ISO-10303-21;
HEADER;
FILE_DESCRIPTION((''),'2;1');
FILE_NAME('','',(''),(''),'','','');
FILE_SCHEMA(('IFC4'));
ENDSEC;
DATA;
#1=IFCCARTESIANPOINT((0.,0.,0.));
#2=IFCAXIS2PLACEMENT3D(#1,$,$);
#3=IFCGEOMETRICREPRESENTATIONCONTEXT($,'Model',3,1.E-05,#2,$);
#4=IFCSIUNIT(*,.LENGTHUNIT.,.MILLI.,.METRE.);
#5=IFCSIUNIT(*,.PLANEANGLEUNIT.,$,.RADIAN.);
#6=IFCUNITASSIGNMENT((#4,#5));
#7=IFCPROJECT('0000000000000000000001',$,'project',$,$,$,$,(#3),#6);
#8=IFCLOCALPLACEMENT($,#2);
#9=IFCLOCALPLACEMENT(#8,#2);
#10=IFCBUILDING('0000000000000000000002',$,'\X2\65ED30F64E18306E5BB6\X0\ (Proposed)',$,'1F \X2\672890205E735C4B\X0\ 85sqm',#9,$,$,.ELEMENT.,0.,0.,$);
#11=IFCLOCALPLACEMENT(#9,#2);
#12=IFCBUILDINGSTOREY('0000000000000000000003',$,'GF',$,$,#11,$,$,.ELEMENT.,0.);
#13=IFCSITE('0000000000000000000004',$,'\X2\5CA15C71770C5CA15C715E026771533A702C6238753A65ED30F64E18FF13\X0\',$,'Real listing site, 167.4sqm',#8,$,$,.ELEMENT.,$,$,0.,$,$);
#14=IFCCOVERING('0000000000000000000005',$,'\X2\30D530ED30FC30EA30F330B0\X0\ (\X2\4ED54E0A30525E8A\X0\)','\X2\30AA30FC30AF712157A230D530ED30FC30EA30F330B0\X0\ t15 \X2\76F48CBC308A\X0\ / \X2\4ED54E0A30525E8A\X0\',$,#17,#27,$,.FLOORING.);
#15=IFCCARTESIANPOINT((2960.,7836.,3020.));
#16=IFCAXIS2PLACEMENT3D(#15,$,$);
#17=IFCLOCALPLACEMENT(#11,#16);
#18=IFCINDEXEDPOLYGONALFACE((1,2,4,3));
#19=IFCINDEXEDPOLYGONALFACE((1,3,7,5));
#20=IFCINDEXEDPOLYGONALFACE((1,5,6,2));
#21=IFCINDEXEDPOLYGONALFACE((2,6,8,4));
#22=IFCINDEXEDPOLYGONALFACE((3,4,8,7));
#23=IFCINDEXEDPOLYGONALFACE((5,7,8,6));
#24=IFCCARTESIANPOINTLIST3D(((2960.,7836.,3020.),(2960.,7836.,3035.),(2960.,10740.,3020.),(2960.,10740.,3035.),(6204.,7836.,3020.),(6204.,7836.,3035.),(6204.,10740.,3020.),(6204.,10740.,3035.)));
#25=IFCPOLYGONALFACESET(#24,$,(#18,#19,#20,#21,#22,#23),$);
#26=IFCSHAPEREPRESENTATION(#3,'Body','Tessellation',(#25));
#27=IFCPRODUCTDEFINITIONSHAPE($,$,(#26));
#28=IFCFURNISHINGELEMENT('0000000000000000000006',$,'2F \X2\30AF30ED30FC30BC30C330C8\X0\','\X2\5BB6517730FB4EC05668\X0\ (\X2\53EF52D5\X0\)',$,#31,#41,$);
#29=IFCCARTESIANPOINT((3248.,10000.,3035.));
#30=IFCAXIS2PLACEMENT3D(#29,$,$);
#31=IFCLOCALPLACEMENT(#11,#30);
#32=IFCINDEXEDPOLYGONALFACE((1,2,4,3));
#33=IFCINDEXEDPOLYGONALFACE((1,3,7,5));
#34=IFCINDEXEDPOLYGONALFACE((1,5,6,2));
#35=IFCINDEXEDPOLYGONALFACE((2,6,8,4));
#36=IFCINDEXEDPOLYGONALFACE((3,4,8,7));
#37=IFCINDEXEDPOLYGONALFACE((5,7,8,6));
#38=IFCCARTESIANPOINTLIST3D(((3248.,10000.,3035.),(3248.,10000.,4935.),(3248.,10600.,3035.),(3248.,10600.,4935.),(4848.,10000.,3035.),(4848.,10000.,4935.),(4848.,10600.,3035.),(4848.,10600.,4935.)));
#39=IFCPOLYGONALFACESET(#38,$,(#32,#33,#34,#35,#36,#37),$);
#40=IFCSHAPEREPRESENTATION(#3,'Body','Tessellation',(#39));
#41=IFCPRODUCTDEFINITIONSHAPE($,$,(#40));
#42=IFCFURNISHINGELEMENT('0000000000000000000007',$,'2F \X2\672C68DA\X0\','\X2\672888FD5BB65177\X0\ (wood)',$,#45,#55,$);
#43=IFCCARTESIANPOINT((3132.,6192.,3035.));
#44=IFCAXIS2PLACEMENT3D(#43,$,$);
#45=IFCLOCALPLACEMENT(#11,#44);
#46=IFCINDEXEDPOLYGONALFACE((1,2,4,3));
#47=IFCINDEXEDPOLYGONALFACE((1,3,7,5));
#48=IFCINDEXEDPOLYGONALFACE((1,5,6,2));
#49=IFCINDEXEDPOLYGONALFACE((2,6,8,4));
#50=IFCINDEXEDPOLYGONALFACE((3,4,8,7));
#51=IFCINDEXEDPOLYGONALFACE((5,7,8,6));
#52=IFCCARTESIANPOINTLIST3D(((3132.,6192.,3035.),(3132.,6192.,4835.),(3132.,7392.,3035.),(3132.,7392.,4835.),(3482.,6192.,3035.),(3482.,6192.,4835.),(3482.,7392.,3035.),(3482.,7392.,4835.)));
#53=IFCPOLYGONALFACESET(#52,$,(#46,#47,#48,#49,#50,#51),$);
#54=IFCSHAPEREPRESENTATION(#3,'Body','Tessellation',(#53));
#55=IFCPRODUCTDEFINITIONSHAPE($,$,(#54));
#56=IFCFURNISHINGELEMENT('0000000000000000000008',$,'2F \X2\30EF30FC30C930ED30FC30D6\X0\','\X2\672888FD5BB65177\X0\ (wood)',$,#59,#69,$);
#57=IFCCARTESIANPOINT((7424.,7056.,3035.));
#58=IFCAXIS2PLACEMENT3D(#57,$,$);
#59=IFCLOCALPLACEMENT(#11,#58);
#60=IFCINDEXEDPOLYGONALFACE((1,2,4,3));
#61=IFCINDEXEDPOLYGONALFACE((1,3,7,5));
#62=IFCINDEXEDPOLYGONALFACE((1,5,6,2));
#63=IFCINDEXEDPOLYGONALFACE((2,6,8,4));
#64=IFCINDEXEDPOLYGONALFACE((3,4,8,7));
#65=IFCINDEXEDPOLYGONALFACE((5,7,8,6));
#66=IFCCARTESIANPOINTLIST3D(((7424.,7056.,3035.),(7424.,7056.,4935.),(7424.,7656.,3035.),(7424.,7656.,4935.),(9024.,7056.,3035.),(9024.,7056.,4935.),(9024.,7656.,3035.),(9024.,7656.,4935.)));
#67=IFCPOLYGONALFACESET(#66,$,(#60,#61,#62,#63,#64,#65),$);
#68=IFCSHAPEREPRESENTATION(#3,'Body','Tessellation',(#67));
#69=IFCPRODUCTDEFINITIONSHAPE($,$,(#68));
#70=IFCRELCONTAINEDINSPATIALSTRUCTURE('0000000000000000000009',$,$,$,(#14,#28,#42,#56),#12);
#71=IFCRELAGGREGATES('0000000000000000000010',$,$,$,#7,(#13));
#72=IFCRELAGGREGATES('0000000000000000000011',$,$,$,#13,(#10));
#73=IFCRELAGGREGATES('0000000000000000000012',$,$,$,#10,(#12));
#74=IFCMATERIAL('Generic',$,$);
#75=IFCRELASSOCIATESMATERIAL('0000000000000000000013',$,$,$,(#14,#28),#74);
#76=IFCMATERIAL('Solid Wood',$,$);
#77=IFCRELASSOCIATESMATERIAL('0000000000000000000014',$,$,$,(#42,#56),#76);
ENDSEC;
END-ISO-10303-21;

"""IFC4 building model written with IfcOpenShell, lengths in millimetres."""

from ifc_helpers import new_model, si_unit, frame, frame_2d, origin, place, context, project, spatial, rectangle, extrude, material, element, save


model = new_model("IFC4")

# Units and contexts
model_context = context("Model", 3, precision=1e-05, world=origin())
ifc_project = project(units=[si_unit("LENGTHUNIT", "METRE", prefix="MILLI"), si_unit("PLANEANGLEUNIT", "RADIAN")], contexts=[model_context])

# Site, building, storey
site_placement = place(None, origin())
site = spatial("IfcSite", under=ifc_project, at=site_placement, Name="岡山県岡山市東区瀬戸町旭ヶ丘３", ObjectType="Real listing site, 167.4sqm", CompositionType="ELEMENT", RefElevation=0.0)
building_placement = place(site_placement, origin())
building = spatial("IfcBuilding", under=site, at=building_placement, Name="旭ヶ丘の家 (Proposed)", ObjectType="1F 木造平屋 85sqm", CompositionType="ELEMENT", ElevationOfRefHeight=0.0, ElevationOfTerrain=0.0)
storey_placement = place(building_placement, origin())
storey = spatial("IfcBuildingStorey", under=building, at=storey_placement, Name="GF", CompositionType="ELEMENT", Elevation=0.0)

# Shared definitions
ifc_material_1 = material(Name="Solid Wood")

# Shared definitions
ifc_material_2 = material(Name="Generic")

# Covering
covering_placement = place(storey_placement, frame((2960.0, 7836.0, 3020.0)))
element("IfcCovering", 1, at=covering_placement, inside=storey, material=ifc_material_2, Name="フローリング (仕上げ床)", Description="オーク無垢フローリング t15 直貼り / 仕上げ床", PredefinedType="FLOORING", context=model_context, shape_type="SweptSolid", body=[
    extrude(rectangle(XDim=3244.0, YDim=2904.0, at=frame_2d((1622.0, 1452.0))), frame((2960.0, 7836.0, 3020.0)), (0.0, 0.0, 1.0), 15.0),
])

# Furnishing elements
furnishing_1_placement = place(storey_placement, frame((3248.0, 10000.0, 3035.0)))
element("IfcFurnishingElement", 2, at=furnishing_1_placement, inside=storey, material=ifc_material_2, Name="2F クローゼット", Description="家具・什器 (可動)", context=model_context, shape_type="SweptSolid", body=[
    extrude(rectangle(XDim=1600.0, YDim=600.0, at=frame_2d((800.0, 300.0))), frame((3248.0, 10000.0, 3035.0)), (0.0, 0.0, 1.0), 1900.0),
])
furnishing_2_placement = place(storey_placement, frame((3132.0, 6192.0, 3035.0)))
element("IfcFurnishingElement", 3, at=furnishing_2_placement, inside=storey, material=ifc_material_1, Name="2F 本棚", Description="木製家具 (wood)", context=model_context, shape_type="SweptSolid", body=[
    extrude(rectangle(XDim=350.0, YDim=1200.0, at=frame_2d((175.0, 600.0))), frame((3132.0, 6192.0, 3035.0)), (0.0, 0.0, 1.0), 1800.0),
])
furnishing_3_placement = place(storey_placement, frame((7424.0, 7056.0, 3035.0)))
element("IfcFurnishingElement", 4, at=furnishing_3_placement, inside=storey, material=ifc_material_1, Name="2F ワードローブ", Description="木製家具 (wood)", context=model_context, shape_type="SweptSolid", body=[
    extrude(rectangle(XDim=1600.0, YDim=600.0, at=frame_2d((800.0, 300.0))), frame((7424.0, 7056.0, 3035.0)), (0.0, 0.0, 1.0), 1900.0),
])

save(model, "model.ifc")
